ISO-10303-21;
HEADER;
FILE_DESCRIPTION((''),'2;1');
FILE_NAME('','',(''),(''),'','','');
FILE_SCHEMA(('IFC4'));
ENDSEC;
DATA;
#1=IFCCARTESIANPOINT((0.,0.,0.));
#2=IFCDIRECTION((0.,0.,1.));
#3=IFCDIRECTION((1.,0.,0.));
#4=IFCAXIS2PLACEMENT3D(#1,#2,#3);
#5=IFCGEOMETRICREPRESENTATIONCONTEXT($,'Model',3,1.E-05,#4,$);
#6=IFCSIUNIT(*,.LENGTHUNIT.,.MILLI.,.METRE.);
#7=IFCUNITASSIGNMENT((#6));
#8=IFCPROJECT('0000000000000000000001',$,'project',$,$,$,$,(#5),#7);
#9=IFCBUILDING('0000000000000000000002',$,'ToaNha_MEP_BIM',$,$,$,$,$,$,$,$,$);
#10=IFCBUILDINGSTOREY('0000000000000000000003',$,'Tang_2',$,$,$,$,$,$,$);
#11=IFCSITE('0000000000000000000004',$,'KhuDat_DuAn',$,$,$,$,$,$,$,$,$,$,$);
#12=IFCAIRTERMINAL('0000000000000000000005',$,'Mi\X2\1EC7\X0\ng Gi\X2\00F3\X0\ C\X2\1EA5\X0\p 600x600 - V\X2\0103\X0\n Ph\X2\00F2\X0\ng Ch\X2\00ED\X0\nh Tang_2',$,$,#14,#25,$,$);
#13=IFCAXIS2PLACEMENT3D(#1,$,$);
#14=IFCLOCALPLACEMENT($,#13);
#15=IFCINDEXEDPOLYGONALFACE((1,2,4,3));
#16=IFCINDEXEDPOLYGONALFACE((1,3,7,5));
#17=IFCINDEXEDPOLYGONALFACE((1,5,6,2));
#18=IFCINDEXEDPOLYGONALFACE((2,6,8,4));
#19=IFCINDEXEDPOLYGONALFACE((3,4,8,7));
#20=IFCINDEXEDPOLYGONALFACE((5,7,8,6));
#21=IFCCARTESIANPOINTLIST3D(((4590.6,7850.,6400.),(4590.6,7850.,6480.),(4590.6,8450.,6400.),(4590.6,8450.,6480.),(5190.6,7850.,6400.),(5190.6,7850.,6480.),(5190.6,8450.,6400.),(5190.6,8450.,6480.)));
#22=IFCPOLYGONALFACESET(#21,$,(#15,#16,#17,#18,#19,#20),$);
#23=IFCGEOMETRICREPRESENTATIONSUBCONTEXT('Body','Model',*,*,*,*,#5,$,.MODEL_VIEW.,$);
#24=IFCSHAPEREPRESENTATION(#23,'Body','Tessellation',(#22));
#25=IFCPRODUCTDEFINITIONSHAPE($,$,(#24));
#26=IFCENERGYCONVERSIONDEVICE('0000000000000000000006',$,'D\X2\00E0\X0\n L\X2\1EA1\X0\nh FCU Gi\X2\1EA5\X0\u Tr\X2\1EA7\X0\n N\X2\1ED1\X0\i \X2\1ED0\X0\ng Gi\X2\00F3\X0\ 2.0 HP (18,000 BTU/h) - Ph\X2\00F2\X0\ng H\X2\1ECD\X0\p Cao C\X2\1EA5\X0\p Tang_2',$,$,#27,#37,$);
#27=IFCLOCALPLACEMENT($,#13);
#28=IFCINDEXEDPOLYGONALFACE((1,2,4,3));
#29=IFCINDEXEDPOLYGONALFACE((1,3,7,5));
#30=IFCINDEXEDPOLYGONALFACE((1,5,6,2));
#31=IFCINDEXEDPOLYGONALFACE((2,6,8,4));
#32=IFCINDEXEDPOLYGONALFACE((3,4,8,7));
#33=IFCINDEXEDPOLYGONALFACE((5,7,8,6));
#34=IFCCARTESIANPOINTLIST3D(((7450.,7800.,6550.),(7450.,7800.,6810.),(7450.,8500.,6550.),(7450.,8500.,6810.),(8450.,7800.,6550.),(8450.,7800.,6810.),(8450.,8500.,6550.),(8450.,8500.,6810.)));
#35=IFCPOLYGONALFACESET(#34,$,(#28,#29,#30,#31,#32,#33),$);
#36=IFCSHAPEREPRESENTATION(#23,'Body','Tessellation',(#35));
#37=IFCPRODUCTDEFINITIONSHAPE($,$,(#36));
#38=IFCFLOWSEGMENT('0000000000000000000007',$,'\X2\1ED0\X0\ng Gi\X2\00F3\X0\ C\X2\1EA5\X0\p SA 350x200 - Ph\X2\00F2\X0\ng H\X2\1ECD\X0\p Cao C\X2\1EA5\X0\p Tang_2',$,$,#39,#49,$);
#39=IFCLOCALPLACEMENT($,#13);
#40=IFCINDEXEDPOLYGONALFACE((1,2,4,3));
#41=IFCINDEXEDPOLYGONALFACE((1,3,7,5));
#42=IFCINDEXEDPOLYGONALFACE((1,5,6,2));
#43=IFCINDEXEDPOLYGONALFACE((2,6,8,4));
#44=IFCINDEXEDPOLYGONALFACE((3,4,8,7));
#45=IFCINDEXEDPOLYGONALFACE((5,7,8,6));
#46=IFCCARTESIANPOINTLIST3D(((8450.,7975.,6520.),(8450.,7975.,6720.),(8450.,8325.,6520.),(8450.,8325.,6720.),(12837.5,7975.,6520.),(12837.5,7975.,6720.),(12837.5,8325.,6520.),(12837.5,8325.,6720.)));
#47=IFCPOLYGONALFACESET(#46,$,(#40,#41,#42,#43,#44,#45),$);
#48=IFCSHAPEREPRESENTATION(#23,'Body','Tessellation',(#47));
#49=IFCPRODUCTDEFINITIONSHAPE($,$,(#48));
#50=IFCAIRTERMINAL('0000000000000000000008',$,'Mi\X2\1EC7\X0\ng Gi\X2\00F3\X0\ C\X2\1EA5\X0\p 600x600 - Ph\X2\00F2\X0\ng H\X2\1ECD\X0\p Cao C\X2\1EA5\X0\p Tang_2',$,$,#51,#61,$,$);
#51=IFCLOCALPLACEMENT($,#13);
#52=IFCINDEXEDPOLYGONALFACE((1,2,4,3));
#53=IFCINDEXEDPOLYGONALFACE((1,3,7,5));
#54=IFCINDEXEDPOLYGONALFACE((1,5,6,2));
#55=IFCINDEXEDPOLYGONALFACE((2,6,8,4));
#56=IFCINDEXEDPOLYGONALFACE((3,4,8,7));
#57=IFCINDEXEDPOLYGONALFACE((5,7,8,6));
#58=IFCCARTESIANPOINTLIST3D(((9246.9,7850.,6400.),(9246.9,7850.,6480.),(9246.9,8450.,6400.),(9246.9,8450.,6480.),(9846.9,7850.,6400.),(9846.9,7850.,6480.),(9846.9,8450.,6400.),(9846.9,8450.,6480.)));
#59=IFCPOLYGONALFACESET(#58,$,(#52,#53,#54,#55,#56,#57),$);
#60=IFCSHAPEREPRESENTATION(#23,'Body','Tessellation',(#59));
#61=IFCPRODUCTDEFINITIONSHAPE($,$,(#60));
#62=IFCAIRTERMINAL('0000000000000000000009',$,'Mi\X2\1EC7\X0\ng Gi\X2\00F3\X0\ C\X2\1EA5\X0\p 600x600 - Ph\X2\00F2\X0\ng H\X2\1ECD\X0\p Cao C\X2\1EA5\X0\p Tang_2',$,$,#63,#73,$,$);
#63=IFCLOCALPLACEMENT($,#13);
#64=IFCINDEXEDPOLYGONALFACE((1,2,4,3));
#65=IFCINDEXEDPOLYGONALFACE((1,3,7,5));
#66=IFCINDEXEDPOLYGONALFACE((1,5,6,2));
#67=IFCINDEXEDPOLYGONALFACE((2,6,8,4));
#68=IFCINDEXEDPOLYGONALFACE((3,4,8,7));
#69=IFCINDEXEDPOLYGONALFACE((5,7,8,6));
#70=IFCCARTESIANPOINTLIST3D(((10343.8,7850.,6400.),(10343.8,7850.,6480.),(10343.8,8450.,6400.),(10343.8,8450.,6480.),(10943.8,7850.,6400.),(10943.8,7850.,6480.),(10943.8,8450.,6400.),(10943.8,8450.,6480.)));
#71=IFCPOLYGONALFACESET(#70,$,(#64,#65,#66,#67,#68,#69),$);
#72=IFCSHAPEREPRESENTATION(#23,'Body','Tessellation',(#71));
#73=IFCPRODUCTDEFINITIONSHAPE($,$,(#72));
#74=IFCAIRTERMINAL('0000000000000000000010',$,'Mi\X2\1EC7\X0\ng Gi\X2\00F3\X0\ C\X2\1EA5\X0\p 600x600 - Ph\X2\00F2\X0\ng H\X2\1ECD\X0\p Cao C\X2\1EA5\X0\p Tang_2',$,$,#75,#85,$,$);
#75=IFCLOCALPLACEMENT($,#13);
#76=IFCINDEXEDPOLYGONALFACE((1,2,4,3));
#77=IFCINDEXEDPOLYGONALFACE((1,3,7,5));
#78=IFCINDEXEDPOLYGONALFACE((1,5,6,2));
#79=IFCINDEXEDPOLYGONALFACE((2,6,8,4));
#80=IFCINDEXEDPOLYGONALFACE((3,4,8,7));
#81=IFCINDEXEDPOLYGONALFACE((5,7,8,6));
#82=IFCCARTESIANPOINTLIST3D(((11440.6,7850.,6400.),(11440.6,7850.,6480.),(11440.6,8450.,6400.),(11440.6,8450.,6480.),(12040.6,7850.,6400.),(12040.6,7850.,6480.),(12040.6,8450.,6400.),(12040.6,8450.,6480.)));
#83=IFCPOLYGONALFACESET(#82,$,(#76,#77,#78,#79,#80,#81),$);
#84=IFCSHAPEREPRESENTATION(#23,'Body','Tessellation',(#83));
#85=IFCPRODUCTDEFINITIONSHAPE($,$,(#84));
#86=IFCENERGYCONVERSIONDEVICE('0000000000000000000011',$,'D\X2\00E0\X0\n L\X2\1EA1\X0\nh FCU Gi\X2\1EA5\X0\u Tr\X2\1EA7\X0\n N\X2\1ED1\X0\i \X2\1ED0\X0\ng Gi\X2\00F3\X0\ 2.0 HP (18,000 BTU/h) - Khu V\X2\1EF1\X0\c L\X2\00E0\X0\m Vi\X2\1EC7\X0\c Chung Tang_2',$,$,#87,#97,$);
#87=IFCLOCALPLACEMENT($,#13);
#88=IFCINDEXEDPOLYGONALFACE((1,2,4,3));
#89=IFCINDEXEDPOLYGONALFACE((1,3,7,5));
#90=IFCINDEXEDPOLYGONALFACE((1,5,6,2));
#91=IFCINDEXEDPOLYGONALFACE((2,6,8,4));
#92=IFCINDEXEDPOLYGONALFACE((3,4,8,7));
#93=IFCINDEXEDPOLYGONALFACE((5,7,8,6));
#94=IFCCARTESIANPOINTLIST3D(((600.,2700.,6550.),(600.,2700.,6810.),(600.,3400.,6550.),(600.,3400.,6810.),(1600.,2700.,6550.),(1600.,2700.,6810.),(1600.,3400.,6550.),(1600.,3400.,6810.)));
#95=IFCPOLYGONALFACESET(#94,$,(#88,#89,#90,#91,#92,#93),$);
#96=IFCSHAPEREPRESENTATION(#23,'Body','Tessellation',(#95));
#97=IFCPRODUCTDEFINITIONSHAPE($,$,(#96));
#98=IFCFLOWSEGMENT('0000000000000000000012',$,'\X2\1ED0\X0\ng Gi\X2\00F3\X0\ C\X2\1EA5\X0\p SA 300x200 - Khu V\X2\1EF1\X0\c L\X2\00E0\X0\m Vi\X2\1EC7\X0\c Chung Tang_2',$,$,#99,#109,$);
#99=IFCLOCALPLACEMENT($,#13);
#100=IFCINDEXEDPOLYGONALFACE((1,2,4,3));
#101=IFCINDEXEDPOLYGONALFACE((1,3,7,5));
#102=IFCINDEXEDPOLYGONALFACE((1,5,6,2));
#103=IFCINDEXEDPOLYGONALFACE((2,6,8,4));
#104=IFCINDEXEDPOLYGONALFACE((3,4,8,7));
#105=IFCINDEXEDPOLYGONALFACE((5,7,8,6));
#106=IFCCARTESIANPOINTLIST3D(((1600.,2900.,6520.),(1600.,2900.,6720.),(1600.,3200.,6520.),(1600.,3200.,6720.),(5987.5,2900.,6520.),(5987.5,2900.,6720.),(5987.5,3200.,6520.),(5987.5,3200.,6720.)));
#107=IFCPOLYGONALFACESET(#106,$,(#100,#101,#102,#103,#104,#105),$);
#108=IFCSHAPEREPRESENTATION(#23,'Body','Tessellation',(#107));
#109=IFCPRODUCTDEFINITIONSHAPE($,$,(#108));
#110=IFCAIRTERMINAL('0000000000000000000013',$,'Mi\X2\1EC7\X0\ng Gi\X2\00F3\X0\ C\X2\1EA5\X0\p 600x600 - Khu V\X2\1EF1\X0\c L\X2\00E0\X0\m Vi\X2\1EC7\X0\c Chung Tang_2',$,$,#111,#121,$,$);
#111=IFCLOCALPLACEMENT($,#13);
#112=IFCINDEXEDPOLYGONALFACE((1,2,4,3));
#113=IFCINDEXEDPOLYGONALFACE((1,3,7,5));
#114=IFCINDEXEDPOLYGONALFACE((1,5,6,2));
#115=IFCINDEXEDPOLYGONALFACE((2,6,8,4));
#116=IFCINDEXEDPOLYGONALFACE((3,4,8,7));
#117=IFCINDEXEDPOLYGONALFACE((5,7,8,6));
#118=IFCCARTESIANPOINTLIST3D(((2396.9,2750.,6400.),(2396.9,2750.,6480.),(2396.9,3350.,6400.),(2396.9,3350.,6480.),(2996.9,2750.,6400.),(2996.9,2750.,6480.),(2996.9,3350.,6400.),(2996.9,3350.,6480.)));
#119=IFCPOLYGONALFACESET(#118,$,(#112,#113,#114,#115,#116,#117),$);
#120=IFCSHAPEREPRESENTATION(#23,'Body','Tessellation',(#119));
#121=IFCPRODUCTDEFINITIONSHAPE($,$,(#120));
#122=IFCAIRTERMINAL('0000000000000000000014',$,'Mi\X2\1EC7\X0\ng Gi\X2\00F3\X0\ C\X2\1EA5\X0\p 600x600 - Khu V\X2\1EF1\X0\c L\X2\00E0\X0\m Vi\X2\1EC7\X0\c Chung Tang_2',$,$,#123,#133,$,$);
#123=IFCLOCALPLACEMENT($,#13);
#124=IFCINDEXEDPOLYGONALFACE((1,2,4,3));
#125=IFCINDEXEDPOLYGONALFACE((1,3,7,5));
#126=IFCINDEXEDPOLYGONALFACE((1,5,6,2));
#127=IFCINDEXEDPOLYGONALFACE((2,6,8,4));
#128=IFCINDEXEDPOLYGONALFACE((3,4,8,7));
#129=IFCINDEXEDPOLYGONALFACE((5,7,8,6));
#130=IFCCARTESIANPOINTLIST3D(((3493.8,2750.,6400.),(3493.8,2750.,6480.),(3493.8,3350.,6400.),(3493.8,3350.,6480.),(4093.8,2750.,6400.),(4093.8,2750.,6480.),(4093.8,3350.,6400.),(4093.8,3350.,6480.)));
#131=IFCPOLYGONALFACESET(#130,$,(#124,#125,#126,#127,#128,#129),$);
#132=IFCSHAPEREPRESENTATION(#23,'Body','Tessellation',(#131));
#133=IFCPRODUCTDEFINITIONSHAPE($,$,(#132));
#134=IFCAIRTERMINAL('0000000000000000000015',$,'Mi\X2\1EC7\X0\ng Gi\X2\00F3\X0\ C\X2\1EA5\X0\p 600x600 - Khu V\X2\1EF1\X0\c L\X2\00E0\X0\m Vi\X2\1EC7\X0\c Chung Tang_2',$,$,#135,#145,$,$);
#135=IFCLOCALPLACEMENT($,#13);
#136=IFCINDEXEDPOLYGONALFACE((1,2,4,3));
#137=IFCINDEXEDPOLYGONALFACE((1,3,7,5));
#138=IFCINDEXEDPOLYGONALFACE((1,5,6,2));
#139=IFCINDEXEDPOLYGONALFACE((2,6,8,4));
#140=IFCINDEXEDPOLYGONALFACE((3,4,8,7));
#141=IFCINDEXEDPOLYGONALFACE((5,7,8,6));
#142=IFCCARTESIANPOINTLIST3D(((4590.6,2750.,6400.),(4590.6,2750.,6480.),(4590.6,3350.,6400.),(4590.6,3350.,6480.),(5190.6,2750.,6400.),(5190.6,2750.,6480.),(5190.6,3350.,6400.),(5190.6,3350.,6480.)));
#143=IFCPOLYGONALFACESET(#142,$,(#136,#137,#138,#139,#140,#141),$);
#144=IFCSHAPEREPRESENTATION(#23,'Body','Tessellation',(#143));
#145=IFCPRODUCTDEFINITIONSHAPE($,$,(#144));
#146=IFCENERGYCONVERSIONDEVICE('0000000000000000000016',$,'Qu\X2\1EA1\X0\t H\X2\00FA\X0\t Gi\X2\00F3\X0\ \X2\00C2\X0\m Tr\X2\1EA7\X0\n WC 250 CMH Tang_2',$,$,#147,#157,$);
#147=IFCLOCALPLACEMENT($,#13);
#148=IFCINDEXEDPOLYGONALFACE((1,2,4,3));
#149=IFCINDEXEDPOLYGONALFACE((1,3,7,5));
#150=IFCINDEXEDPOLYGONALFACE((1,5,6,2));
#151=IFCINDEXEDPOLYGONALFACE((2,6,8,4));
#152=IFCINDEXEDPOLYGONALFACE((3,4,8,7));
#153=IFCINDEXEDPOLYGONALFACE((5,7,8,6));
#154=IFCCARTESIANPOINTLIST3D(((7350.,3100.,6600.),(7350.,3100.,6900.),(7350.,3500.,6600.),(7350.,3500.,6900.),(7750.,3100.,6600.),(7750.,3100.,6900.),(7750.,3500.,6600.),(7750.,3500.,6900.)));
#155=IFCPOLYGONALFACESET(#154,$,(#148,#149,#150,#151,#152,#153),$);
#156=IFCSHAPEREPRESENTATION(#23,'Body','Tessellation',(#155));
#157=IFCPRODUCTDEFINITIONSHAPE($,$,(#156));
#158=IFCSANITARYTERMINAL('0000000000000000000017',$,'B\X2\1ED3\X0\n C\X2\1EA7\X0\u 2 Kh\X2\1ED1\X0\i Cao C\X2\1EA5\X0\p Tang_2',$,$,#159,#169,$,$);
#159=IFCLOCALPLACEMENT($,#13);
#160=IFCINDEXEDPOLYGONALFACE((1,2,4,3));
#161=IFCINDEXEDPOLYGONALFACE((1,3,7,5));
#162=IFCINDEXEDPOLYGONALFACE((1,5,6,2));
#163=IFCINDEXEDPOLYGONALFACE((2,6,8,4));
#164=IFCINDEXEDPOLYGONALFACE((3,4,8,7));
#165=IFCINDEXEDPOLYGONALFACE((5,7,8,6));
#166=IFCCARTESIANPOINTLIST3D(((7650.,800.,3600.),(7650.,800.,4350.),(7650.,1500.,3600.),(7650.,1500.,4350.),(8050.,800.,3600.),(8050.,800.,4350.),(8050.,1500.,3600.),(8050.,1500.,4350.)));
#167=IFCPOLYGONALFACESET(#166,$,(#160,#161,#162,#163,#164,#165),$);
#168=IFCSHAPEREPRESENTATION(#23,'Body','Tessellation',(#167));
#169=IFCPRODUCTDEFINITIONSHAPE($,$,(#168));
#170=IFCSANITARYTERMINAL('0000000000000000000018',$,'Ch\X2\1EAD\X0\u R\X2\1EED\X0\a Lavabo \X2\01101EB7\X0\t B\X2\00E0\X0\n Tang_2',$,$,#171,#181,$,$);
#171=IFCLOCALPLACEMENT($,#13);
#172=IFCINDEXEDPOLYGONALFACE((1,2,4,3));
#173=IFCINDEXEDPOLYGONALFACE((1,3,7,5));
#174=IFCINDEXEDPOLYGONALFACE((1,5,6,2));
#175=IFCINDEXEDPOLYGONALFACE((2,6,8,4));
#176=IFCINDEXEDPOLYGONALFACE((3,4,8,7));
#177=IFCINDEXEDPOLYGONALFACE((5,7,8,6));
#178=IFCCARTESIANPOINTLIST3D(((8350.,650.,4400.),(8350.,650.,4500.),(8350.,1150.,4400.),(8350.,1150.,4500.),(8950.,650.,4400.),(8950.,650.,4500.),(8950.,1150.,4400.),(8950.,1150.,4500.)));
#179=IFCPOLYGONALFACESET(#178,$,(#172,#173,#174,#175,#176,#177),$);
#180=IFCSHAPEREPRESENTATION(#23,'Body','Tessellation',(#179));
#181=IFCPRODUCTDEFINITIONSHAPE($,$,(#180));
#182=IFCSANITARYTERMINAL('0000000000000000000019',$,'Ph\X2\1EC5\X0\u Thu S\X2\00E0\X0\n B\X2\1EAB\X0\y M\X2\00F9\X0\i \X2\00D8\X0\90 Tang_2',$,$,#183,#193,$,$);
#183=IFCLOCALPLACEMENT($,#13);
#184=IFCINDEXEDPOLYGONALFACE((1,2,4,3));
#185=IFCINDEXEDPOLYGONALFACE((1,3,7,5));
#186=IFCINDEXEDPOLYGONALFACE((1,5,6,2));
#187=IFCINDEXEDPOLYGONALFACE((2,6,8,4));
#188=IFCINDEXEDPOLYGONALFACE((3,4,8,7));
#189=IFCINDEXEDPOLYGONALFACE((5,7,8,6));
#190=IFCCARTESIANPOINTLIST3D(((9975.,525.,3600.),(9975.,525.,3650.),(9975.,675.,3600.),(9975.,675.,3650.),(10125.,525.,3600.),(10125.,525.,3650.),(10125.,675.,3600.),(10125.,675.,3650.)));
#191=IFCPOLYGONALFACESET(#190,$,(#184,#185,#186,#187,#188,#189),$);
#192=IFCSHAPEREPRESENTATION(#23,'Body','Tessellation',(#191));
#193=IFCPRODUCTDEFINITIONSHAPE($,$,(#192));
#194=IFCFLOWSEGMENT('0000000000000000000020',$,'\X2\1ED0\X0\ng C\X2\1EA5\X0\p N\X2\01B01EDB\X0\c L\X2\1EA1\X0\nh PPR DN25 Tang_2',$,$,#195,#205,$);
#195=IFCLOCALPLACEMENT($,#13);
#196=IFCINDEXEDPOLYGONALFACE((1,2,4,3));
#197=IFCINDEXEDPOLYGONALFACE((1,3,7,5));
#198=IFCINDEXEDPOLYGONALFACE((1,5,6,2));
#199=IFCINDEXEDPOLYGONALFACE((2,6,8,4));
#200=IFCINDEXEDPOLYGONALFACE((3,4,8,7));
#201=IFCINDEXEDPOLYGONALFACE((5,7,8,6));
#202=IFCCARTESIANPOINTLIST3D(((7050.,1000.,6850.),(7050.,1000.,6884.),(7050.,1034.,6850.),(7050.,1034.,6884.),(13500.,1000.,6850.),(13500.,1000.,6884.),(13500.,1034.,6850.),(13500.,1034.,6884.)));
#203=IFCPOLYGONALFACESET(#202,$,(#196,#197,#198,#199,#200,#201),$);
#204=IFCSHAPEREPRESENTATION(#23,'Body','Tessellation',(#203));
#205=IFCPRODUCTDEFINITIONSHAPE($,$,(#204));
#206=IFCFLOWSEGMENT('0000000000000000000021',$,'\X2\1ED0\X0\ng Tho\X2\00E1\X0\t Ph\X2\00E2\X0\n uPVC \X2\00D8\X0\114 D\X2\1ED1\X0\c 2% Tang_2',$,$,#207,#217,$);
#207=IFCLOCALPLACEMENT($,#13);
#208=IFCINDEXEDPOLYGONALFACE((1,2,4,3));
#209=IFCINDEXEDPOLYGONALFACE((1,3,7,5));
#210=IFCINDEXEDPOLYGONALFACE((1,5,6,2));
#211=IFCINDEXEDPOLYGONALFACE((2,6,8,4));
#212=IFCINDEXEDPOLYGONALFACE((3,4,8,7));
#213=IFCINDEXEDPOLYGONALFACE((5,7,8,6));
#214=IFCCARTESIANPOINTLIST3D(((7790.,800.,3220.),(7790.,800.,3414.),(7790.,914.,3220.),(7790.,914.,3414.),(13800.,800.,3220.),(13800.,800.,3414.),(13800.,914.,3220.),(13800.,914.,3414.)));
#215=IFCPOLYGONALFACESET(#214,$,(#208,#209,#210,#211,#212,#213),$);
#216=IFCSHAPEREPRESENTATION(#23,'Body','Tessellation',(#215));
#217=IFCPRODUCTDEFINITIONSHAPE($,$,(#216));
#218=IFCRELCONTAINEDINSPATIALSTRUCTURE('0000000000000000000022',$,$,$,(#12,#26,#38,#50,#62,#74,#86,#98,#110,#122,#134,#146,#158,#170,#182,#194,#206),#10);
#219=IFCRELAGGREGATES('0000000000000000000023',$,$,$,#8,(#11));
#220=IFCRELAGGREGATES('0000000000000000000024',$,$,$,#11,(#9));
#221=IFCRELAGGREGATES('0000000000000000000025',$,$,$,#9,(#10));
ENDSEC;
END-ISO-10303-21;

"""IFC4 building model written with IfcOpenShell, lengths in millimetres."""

from ifc_helpers import new_model, si_unit, frame, origin_with_axes, context, subcontext, project, spatial, polyline, outline, extrude, element, save


model = new_model("IFC4")

# Units and contexts
model_context = context("Model", 3, precision=1e-05, world=origin_with_axes())
body_context = subcontext(model_context, "Body", "Model", "MODEL_VIEW")
ifc_project = project(units=[si_unit("LENGTHUNIT", "METRE", prefix="MILLI")], contexts=[model_context])

# Site, building, storey
site = spatial("IfcSite", under=ifc_project, Name="KhuDat_DuAn")
building = spatial("IfcBuilding", under=site, Name="ToaNha_MEP_BIM")
storey = spatial("IfcBuildingStorey", under=building, Name="Tang_2")

# Air terminal
element("IfcAirTerminal", 1, inside=storey, Name="Miệng Gió Cấp 600x600 - Văn Phòng Chính Tang_2", context=body_context, shape_type="SweptSolid", body=[
    extrude(outline(polyline([(4590.6, 7850.0), (5190.6, 7850.0), (5190.6, 8450.0), (4590.6, 8450.0), (4590.6, 7850.0)])), frame((0.0, 0.0, 6400.0), z_axis=(0.0, 0.0, 1.0), x_axis=(1.0, 0.0, 0.0)), (0.0, 0.0, 1.0), 80.0),
])

# Energy conversion device
element("IfcEnergyConversionDevice", 2, inside=storey, Name="Dàn Lạnh FCU Giấu Trần Nối Ống Gió 2.0 HP (18,000 BTU/h) - Phòng Họp Cao Cấp Tang_2", context=body_context, shape_type="SweptSolid", body=[
    extrude(outline(polyline([(7450.0, 7800.0), (8450.0, 7800.0), (8450.0, 8500.0), (7450.0, 8500.0), (7450.0, 7800.0)])), frame((0.0, 0.0, 6550.0), z_axis=(0.0, 0.0, 1.0), x_axis=(1.0, 0.0, 0.0)), (0.0, 0.0, 1.0), 260.0),
])

# Flow segment
element("IfcFlowSegment", 3, inside=storey, Name="Ống Gió Cấp SA 350x200 - Phòng Họp Cao Cấp Tang_2", context=body_context, shape_type="SweptSolid", body=[
    extrude(outline(polyline([(8450.0, 7975.0), (12837.5, 7975.0), (12837.5, 8325.0), (8450.0, 8325.0), (8450.0, 7975.0)])), frame((0.0, 0.0, 6520.0), z_axis=(0.0, 0.0, 1.0), x_axis=(1.0, 0.0, 0.0)), (0.0, 0.0, 1.0), 200.0),
])

# Air terminals
element("IfcAirTerminal", 4, inside=storey, Name="Miệng Gió Cấp 600x600 - Phòng Họp Cao Cấp Tang_2", context=body_context, shape_type="SweptSolid", body=[
    extrude(outline(polyline([(9246.9, 7850.0), (9846.9, 7850.0), (9846.9, 8450.0), (9246.9, 8450.0), (9246.9, 7850.0)])), frame((0.0, 0.0, 6400.0), z_axis=(0.0, 0.0, 1.0), x_axis=(1.0, 0.0, 0.0)), (0.0, 0.0, 1.0), 80.0),
])
element("IfcAirTerminal", 5, inside=storey, Name="Miệng Gió Cấp 600x600 - Phòng Họp Cao Cấp Tang_2", context=body_context, shape_type="SweptSolid", body=[
    extrude(outline(polyline([(10343.8, 7850.0), (10943.8, 7850.0), (10943.8, 8450.0), (10343.8, 8450.0), (10343.8, 7850.0)])), frame((0.0, 0.0, 6400.0), z_axis=(0.0, 0.0, 1.0), x_axis=(1.0, 0.0, 0.0)), (0.0, 0.0, 1.0), 80.0),
])
element("IfcAirTerminal", 6, inside=storey, Name="Miệng Gió Cấp 600x600 - Phòng Họp Cao Cấp Tang_2", context=body_context, shape_type="SweptSolid", body=[
    extrude(outline(polyline([(11440.6, 7850.0), (12040.6, 7850.0), (12040.6, 8450.0), (11440.6, 8450.0), (11440.6, 7850.0)])), frame((0.0, 0.0, 6400.0), z_axis=(0.0, 0.0, 1.0), x_axis=(1.0, 0.0, 0.0)), (0.0, 0.0, 1.0), 80.0),
])

# Energy conversion device
element("IfcEnergyConversionDevice", 7, inside=storey, Name="Dàn Lạnh FCU Giấu Trần Nối Ống Gió 2.0 HP (18,000 BTU/h) - Khu Vực Làm Việc Chung Tang_2", context=body_context, shape_type="SweptSolid", body=[
    extrude(outline(polyline([(600.0, 2700.0), (1600.0, 2700.0), (1600.0, 3400.0), (600.0, 3400.0), (600.0, 2700.0)])), frame((0.0, 0.0, 6550.0), z_axis=(0.0, 0.0, 1.0), x_axis=(1.0, 0.0, 0.0)), (0.0, 0.0, 1.0), 260.0),
])

# Flow segment
element("IfcFlowSegment", 8, inside=storey, Name="Ống Gió Cấp SA 300x200 - Khu Vực Làm Việc Chung Tang_2", context=body_context, shape_type="SweptSolid", body=[
    extrude(outline(polyline([(1600.0, 2900.0), (5987.5, 2900.0), (5987.5, 3200.0), (1600.0, 3200.0), (1600.0, 2900.0)])), frame((0.0, 0.0, 6520.0), z_axis=(0.0, 0.0, 1.0), x_axis=(1.0, 0.0, 0.0)), (0.0, 0.0, 1.0), 200.0),
])

# Air terminals
element("IfcAirTerminal", 9, inside=storey, Name="Miệng Gió Cấp 600x600 - Khu Vực Làm Việc Chung Tang_2", context=body_context, shape_type="SweptSolid", body=[
    extrude(outline(polyline([(2396.9, 2750.0), (2996.9, 2750.0), (2996.9, 3350.0), (2396.9, 3350.0), (2396.9, 2750.0)])), frame((0.0, 0.0, 6400.0), z_axis=(0.0, 0.0, 1.0), x_axis=(1.0, 0.0, 0.0)), (0.0, 0.0, 1.0), 80.0),
])
element("IfcAirTerminal", 10, inside=storey, Name="Miệng Gió Cấp 600x600 - Khu Vực Làm Việc Chung Tang_2", context=body_context, shape_type="SweptSolid", body=[
    extrude(outline(polyline([(3493.8, 2750.0), (4093.8, 2750.0), (4093.8, 3350.0), (3493.8, 3350.0), (3493.8, 2750.0)])), frame((0.0, 0.0, 6400.0), z_axis=(0.0, 0.0, 1.0), x_axis=(1.0, 0.0, 0.0)), (0.0, 0.0, 1.0), 80.0),
])
element("IfcAirTerminal", 11, inside=storey, Name="Miệng Gió Cấp 600x600 - Khu Vực Làm Việc Chung Tang_2", context=body_context, shape_type="SweptSolid", body=[
    extrude(outline(polyline([(4590.6, 2750.0), (5190.6, 2750.0), (5190.6, 3350.0), (4590.6, 3350.0), (4590.6, 2750.0)])), frame((0.0, 0.0, 6400.0), z_axis=(0.0, 0.0, 1.0), x_axis=(1.0, 0.0, 0.0)), (0.0, 0.0, 1.0), 80.0),
])

# Energy conversion device
element("IfcEnergyConversionDevice", 12, inside=storey, Name="Quạt Hút Gió Âm Trần WC 250 CMH Tang_2", context=body_context, shape_type="SweptSolid", body=[
    extrude(outline(polyline([(7350.0, 3100.0), (7750.0, 3100.0), (7750.0, 3500.0), (7350.0, 3500.0), (7350.0, 3100.0)])), frame((0.0, 0.0, 6600.0), z_axis=(0.0, 0.0, 1.0), x_axis=(1.0, 0.0, 0.0)), (0.0, 0.0, 1.0), 300.0),
])

# Sanitary terminals
element("IfcSanitaryTerminal", 13, inside=storey, Name="Bồn Cầu 2 Khối Cao Cấp Tang_2", context=body_context, shape_type="SweptSolid", body=[
    extrude(outline(polyline([(7650.0, 800.0), (8050.0, 800.0), (8050.0, 1500.0), (7650.0, 1500.0), (7650.0, 800.0)])), frame((0.0, 0.0, 3600.0), z_axis=(0.0, 0.0, 1.0), x_axis=(1.0, 0.0, 0.0)), (0.0, 0.0, 1.0), 750.0),
])
element("IfcSanitaryTerminal", 14, inside=storey, Name="Chậu Rửa Lavabo Đặt Bàn Tang_2", context=body_context, shape_type="SweptSolid", body=[
    extrude(outline(polyline([(8350.0, 650.0), (8950.0, 650.0), (8950.0, 1150.0), (8350.0, 1150.0), (8350.0, 650.0)])), frame((0.0, 0.0, 4400.0), z_axis=(0.0, 0.0, 1.0), x_axis=(1.0, 0.0, 0.0)), (0.0, 0.0, 1.0), 100.0),
])
element("IfcSanitaryTerminal", 15, inside=storey, Name="Phễu Thu Sàn Bẫy Mùi Ø90 Tang_2", context=body_context, shape_type="SweptSolid", body=[
    extrude(outline(polyline([(9975.0, 525.0), (10125.0, 525.0), (10125.0, 675.0), (9975.0, 675.0), (9975.0, 525.0)])), frame((0.0, 0.0, 3600.0), z_axis=(0.0, 0.0, 1.0), x_axis=(1.0, 0.0, 0.0)), (0.0, 0.0, 1.0), 50.0),
])

# Flow segments
element("IfcFlowSegment", 16, inside=storey, Name="Ống Cấp Nước Lạnh PPR DN25 Tang_2", context=body_context, shape_type="SweptSolid", body=[
    extrude(outline(polyline([(7050.0, 1000.0), (13500.0, 1000.0), (13500.0, 1034.0), (7050.0, 1034.0), (7050.0, 1000.0)])), frame((0.0, 0.0, 6850.0), z_axis=(0.0, 0.0, 1.0), x_axis=(1.0, 0.0, 0.0)), (0.0, 0.0, 1.0), 34.0),
])
element("IfcFlowSegment", 17, inside=storey, Name="Ống Thoát Phân uPVC Ø114 Dốc 2% Tang_2", context=body_context, shape_type="SweptSolid", body=[
    extrude(outline(polyline([(7790.0, 800.0), (13800.0, 800.0), (13800.0, 914.0), (7790.0, 914.0), (7790.0, 800.0)])), frame((0.0, 0.0, 3220.0), z_axis=(0.0, 0.0, 1.0), x_axis=(1.0, 0.0, 0.0)), (0.0, 0.0, 1.0), 194.0),
])

save(model, "model.ifc")
